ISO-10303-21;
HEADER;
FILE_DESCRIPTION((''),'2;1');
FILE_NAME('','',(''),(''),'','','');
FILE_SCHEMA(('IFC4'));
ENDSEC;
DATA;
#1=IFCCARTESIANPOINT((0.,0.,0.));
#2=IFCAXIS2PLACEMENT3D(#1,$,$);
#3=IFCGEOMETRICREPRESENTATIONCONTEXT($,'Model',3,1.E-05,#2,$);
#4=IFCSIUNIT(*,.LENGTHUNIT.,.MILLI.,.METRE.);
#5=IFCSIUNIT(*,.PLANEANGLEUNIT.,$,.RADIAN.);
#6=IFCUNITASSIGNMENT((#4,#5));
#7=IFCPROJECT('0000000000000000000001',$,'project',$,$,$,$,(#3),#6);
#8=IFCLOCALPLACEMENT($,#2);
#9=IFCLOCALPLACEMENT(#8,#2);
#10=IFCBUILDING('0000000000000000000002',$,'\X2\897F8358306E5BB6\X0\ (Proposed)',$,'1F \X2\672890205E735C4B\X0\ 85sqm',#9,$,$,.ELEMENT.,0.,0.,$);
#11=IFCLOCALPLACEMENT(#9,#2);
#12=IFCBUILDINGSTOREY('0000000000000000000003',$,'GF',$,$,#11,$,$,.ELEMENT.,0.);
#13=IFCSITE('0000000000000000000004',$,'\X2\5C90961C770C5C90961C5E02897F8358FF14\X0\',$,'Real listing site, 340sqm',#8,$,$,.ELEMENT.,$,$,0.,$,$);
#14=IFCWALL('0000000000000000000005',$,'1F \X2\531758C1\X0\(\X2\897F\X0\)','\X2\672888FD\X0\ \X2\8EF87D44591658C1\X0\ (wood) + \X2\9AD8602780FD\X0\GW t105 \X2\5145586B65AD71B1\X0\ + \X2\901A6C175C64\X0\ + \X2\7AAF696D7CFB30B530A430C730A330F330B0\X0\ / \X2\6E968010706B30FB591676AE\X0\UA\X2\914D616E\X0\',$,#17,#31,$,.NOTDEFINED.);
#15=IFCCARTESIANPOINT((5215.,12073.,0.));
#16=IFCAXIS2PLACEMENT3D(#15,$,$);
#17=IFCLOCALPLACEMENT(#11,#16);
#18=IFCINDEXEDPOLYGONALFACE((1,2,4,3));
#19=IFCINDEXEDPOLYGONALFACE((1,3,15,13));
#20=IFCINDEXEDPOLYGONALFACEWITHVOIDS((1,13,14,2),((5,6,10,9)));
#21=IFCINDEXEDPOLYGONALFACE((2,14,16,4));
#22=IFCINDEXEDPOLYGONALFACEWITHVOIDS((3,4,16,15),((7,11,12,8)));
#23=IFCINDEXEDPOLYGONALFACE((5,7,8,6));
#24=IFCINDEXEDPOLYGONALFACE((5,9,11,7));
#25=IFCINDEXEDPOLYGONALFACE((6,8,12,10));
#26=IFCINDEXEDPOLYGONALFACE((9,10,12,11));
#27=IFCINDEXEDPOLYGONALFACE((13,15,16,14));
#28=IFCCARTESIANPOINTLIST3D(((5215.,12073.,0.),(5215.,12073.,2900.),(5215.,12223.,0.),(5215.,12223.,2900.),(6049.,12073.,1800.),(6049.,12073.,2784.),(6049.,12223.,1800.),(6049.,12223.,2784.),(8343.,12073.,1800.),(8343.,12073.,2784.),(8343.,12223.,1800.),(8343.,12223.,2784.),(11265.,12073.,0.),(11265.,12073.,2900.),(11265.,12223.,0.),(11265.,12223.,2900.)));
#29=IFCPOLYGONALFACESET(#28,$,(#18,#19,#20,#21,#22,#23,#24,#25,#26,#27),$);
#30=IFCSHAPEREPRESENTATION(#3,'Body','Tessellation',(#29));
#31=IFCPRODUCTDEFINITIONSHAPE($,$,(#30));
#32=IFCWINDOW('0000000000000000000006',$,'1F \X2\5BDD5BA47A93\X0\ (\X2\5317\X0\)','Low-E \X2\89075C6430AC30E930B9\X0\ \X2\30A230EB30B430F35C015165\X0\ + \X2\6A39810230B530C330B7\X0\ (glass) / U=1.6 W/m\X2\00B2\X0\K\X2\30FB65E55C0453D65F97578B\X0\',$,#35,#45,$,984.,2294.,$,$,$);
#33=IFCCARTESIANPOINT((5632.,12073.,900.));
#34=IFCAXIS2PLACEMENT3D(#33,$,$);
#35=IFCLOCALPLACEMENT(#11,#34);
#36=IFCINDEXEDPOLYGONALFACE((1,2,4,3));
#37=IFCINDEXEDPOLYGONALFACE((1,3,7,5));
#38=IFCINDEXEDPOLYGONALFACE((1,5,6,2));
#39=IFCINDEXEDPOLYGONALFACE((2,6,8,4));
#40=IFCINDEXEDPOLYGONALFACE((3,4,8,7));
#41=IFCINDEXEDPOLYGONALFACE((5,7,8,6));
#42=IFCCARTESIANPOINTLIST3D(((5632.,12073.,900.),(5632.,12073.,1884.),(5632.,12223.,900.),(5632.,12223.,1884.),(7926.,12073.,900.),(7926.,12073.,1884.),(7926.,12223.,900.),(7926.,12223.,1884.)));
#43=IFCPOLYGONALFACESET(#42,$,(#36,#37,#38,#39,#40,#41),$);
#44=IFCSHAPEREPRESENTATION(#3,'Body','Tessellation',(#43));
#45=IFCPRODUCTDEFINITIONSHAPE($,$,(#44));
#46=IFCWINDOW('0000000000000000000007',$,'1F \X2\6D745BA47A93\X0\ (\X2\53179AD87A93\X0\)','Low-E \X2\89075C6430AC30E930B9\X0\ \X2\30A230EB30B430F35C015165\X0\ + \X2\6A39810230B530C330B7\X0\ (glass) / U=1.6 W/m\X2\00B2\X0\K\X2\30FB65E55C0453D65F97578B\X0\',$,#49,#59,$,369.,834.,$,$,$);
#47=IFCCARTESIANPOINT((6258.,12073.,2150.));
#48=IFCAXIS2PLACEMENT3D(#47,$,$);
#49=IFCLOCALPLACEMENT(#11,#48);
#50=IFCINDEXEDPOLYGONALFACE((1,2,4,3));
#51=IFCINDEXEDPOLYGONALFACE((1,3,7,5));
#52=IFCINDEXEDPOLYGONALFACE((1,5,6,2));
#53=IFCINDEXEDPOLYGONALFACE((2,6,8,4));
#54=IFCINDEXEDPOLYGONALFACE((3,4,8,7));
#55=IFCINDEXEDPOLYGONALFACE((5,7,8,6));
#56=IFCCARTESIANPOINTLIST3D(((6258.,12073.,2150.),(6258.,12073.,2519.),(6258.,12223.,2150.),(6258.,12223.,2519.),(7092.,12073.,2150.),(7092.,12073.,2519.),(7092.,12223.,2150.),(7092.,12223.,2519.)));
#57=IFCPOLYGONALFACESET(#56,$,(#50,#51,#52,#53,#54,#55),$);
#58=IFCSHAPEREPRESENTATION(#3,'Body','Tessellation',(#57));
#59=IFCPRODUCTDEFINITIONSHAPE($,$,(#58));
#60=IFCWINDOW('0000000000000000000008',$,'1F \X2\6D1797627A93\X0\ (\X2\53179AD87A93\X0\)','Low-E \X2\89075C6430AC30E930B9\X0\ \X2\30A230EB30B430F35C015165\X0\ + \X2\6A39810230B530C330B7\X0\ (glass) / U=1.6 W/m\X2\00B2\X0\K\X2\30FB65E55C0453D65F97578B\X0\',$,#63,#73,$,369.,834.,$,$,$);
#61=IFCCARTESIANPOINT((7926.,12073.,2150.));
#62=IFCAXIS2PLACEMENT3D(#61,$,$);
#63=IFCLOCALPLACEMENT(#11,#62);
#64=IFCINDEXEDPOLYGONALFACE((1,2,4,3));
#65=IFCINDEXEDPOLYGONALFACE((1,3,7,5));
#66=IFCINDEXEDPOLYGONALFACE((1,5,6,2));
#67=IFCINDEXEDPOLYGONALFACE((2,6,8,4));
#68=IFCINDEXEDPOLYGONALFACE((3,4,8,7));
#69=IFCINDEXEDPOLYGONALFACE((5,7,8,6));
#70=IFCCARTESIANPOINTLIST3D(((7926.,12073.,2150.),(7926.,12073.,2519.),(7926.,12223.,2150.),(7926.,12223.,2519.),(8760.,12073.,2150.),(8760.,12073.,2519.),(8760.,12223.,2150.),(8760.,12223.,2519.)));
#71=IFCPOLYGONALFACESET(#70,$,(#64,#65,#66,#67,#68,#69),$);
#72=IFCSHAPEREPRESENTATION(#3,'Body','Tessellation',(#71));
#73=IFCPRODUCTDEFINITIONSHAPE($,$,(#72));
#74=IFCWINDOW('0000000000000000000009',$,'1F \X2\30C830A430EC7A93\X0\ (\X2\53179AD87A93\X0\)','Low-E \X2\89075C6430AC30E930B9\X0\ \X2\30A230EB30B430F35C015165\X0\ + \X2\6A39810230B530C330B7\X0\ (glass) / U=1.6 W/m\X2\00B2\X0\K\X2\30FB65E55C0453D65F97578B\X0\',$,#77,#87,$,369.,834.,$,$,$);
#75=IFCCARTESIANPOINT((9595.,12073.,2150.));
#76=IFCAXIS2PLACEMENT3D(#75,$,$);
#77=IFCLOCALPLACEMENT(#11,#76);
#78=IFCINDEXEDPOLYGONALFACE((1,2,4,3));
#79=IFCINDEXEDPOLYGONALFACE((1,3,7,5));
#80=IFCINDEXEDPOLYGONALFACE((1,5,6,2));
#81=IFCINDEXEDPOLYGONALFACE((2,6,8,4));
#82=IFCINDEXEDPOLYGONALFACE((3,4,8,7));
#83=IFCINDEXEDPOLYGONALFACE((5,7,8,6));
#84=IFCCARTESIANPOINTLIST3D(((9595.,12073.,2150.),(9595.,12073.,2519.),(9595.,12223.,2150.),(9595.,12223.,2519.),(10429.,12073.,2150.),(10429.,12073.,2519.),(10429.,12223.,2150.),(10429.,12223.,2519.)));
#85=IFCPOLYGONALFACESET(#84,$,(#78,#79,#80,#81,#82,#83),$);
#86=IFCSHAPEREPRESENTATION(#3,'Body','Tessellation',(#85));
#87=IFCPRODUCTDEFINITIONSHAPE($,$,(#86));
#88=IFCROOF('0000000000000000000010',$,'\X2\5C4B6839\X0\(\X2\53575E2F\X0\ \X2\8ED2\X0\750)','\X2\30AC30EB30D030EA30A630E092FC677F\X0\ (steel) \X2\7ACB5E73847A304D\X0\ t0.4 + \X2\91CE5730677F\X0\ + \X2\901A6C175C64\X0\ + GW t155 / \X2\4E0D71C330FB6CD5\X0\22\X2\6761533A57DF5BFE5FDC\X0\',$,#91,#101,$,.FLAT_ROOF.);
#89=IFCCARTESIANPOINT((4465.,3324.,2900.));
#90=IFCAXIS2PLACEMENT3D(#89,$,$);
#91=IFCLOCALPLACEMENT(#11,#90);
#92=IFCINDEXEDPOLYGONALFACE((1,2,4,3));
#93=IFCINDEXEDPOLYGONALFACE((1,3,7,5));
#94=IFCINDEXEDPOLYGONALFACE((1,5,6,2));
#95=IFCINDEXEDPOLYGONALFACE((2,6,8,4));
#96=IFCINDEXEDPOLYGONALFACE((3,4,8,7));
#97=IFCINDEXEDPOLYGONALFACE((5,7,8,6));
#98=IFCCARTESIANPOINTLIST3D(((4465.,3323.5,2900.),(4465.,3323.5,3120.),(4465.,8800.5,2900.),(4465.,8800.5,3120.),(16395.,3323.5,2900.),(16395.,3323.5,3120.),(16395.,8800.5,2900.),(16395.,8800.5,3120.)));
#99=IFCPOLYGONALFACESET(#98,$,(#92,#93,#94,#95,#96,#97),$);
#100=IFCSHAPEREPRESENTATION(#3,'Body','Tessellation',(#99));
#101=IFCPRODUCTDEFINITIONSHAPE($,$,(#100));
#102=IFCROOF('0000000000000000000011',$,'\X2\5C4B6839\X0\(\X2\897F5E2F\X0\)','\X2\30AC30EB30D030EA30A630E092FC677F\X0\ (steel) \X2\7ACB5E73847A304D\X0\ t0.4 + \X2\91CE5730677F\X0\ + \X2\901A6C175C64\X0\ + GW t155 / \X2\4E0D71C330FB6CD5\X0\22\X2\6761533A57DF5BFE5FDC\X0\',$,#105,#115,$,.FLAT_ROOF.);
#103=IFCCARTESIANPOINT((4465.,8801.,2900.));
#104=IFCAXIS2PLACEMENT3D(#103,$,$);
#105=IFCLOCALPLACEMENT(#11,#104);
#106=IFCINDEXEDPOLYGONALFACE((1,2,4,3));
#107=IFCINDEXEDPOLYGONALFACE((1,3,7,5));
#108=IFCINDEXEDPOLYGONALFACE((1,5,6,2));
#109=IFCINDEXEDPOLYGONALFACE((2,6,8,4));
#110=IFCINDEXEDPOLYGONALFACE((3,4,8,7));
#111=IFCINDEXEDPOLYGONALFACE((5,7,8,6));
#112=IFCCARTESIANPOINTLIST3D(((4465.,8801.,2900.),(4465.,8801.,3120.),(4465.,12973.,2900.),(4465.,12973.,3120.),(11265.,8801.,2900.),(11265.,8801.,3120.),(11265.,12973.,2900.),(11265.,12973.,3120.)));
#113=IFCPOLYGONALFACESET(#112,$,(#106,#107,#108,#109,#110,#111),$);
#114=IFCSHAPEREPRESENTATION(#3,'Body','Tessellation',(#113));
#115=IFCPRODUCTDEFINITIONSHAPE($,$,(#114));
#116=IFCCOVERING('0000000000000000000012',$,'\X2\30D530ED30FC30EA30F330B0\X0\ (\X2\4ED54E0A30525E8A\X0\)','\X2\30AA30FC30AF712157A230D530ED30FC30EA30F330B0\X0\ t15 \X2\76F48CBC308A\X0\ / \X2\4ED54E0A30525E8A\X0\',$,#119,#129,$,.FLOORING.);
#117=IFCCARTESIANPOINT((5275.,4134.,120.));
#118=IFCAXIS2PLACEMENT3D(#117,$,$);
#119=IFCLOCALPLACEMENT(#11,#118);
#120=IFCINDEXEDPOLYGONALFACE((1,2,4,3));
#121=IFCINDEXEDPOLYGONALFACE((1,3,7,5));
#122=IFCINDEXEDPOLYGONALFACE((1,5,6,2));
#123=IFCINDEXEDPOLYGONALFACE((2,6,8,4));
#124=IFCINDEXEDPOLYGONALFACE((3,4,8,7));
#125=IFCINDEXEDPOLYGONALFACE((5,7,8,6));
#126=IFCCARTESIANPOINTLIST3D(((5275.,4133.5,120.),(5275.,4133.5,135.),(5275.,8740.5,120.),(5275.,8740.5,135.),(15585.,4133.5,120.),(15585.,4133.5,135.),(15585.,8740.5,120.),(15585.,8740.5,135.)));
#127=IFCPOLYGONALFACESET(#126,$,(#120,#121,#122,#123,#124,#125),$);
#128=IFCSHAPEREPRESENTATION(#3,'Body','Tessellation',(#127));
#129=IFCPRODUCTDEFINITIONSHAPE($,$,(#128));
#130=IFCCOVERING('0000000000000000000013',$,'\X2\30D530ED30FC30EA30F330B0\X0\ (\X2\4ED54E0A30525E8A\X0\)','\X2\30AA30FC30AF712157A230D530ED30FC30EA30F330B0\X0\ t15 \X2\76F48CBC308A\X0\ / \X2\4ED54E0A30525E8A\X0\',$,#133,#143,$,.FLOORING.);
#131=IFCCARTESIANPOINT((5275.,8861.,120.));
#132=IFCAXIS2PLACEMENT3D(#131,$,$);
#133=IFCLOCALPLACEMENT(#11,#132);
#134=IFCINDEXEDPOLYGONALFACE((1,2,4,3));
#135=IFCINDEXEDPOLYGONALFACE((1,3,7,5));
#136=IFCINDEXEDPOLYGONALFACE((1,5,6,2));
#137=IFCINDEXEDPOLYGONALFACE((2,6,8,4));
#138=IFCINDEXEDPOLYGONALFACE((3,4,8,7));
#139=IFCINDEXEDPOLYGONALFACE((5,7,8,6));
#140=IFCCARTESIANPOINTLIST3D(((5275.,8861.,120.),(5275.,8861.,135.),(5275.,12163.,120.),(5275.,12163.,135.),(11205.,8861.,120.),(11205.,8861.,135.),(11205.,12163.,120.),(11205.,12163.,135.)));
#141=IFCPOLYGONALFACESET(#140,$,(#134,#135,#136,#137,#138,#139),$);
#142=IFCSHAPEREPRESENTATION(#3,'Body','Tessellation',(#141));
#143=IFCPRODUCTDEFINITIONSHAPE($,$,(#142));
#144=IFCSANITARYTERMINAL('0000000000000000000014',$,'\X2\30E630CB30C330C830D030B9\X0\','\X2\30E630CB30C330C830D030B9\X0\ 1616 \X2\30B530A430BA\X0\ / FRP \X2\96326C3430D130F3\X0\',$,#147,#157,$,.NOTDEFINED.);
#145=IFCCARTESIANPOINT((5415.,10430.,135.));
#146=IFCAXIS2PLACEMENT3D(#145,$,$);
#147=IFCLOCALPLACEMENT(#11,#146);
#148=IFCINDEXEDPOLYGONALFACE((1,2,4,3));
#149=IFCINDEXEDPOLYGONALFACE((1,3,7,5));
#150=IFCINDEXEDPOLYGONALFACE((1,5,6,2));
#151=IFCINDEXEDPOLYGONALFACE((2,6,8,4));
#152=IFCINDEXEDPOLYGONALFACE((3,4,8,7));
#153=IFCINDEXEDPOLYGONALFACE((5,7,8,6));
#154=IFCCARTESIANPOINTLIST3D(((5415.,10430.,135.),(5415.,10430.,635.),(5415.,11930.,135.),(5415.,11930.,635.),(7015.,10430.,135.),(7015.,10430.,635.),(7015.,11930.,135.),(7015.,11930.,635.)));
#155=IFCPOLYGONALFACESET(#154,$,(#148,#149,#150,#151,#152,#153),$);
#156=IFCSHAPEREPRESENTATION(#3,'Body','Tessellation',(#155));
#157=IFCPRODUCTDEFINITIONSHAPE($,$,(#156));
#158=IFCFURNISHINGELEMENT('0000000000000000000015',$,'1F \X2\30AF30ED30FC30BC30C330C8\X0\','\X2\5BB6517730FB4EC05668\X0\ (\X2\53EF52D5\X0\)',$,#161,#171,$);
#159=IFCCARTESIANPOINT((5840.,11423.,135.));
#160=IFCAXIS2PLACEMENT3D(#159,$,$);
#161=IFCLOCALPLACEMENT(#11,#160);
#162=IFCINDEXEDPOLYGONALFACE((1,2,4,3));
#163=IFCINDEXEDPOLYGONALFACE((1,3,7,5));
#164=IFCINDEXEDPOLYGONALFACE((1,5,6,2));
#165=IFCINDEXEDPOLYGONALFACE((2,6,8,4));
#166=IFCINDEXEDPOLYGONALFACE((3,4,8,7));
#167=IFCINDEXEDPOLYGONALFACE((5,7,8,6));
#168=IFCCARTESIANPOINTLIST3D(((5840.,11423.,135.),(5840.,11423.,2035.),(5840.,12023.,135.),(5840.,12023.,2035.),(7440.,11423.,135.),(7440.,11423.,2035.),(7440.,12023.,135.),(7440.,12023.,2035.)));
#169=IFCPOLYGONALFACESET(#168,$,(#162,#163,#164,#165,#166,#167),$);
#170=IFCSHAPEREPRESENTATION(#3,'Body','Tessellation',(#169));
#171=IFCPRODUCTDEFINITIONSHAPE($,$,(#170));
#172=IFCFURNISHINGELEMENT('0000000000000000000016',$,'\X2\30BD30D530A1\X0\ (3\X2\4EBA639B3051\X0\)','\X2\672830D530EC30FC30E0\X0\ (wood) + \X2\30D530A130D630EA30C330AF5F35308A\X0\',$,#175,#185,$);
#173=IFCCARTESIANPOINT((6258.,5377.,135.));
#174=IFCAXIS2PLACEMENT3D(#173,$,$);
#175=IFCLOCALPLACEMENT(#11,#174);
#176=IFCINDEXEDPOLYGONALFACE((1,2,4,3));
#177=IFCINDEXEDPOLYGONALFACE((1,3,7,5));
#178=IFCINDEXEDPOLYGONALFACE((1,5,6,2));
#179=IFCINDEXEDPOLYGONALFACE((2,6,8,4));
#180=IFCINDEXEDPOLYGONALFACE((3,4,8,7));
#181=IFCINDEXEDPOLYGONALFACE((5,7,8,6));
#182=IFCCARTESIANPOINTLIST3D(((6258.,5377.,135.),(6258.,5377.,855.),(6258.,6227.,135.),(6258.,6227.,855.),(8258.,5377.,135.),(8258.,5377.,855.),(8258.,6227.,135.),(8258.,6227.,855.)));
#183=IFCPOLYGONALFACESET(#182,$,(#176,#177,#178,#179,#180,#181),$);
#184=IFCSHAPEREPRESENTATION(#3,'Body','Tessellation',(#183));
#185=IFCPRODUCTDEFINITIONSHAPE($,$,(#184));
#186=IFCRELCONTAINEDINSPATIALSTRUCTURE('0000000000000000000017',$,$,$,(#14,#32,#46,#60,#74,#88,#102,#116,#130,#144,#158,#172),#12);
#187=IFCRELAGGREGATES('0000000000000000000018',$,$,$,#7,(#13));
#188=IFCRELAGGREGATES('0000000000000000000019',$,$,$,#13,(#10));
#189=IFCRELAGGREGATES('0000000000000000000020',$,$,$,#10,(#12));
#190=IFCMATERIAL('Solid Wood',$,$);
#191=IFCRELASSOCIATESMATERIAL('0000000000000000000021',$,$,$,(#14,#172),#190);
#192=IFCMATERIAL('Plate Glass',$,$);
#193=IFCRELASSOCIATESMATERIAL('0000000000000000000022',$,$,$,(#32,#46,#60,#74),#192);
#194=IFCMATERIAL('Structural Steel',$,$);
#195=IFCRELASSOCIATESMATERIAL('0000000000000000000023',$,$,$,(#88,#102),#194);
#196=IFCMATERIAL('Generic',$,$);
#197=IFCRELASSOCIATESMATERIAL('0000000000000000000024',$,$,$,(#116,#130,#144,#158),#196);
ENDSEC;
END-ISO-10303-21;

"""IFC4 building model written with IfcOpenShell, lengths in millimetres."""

from ifc_helpers import new_model, si_unit, frame, frame_2d, origin, place, context, project, spatial, rectangle, extrude, material, element, fill, save


model = new_model("IFC4")

# Units and contexts
model_context = context("Model", 3, precision=1e-05, world=origin())
ifc_project = project(units=[si_unit("LENGTHUNIT", "METRE", prefix="MILLI"), si_unit("PLANEANGLEUNIT", "RADIAN")], contexts=[model_context])

# Site, building, storey
site_placement = place(None, origin())
site = spatial("IfcSite", under=ifc_project, at=site_placement, Name="岐阜県岐阜市西荘４", ObjectType="Real listing site, 340sqm", CompositionType="ELEMENT", RefElevation=0.0)
building_placement = place(site_placement, origin())
building = spatial("IfcBuilding", under=site, at=building_placement, Name="西荘の家 (Proposed)", ObjectType="1F 木造平屋 85sqm", CompositionType="ELEMENT", ElevationOfRefHeight=0.0, ElevationOfTerrain=0.0)
storey_placement = place(building_placement, origin())
storey = spatial("IfcBuildingStorey", under=building, at=storey_placement, Name="GF", CompositionType="ELEMENT", Elevation=0.0)

# Shared definitions
ifc_material_1 = material(Name="Solid Wood")

# Shared definitions
ifc_material_2 = material(Name="Plate Glass")

# Wall, openings, windows
wall_1_placement = place(storey_placement, frame((5215.0, 12073.0, 0.0)))
wall_1 = element("IfcWall", 1, at=wall_1_placement, inside=storey, material=ifc_material_1, Name="1F 北壁(西)", Description="木製 軸組外壁 (wood) + 高性能GW t105 充填断熱 + 通気層 + 窯業系サイディング / 準耐火・外皮UA配慮", PredefinedType="NOTDEFINED", context=model_context, shape_type="SweptSolid", body=[
    extrude(rectangle(XDim=6050.0, YDim=150.0, at=frame_2d((3025.0, 75.0))), frame((5215.0, 12073.0, 0.0)), (0.0, 0.0, 1.0), 2900.0),
])
opening_1_placement = place(storey_placement, frame((5632.0, 12073.0, 900.0)))
opening_1 = element("IfcOpeningElement", 2, at=opening_1_placement, cuts=wall_1, PredefinedType="NOTDEFINED", context=model_context, shape_type="SweptSolid", body=[
    extrude(rectangle(XDim=2294.0, YDim=150.0, at=frame_2d((1147.0, 75.0))), frame((5632.0, 12073.0, 900.0)), (0.0, 0.0, 1.0), 984.0),
])
opening_2_placement = place(storey_placement, frame((6258.0, 12073.0, 2150.0)))
opening_2 = element("IfcOpeningElement", 3, at=opening_2_placement, cuts=wall_1, PredefinedType="NOTDEFINED", context=model_context, shape_type="SweptSolid", body=[
    extrude(rectangle(XDim=834.0, YDim=150.0, at=frame_2d((417.0, 75.0))), frame((6258.0, 12073.0, 2150.0)), (0.0, 0.0, 1.0), 369.0),
])
opening_3_placement = place(storey_placement, frame((7926.0, 12073.0, 2150.0)))
opening_3 = element("IfcOpeningElement", 4, at=opening_3_placement, cuts=wall_1, PredefinedType="NOTDEFINED", context=model_context, shape_type="SweptSolid", body=[
    extrude(rectangle(XDim=834.0, YDim=150.0, at=frame_2d((417.0, 75.0))), frame((7926.0, 12073.0, 2150.0)), (0.0, 0.0, 1.0), 369.0),
])
opening_4_placement = place(storey_placement, frame((9595.0, 12073.0, 2150.0)))
opening_4 = element("IfcOpeningElement", 5, at=opening_4_placement, cuts=wall_1, PredefinedType="NOTDEFINED", context=model_context, shape_type="SweptSolid", body=[
    extrude(rectangle(XDim=834.0, YDim=150.0, at=frame_2d((417.0, 75.0))), frame((9595.0, 12073.0, 2150.0)), (0.0, 0.0, 1.0), 369.0),
])
window_1_placement = place(storey_placement, frame((5632.0, 12073.0, 900.0)))
window_1 = element("IfcWindow", 6, at=window_1_placement, inside=storey, material=ifc_material_2, Name="1F 寝室窓 (北)", Description="Low-E 複層ガラス アルゴン封入 + 樹脂サッシ (glass) / U=1.6 W/m²K・日射取得型", OverallHeight=984.0, OverallWidth=2294.0, context=model_context, shape_type="SweptSolid", body=[
    extrude(rectangle(XDim=2294.0, YDim=150.0, at=frame_2d((1147.0, 75.0))), frame((5632.0, 12073.0, 900.0)), (0.0, 0.0, 1.0), 984.0),
])
fill(opening_1, window_1)
window_2_placement = place(storey_placement, frame((6258.0, 12073.0, 2150.0)))
window_2 = element("IfcWindow", 7, at=window_2_placement, inside=storey, material=ifc_material_2, Name="1F 浴室窓 (北高窓)", Description="Low-E 複層ガラス アルゴン封入 + 樹脂サッシ (glass) / U=1.6 W/m²K・日射取得型", OverallHeight=369.0, OverallWidth=834.0, context=model_context, shape_type="SweptSolid", body=[
    extrude(rectangle(XDim=834.0, YDim=150.0, at=frame_2d((417.0, 75.0))), frame((6258.0, 12073.0, 2150.0)), (0.0, 0.0, 1.0), 369.0),
])
fill(opening_2, window_2)
window_3_placement = place(storey_placement, frame((7926.0, 12073.0, 2150.0)))
window_3 = element("IfcWindow", 8, at=window_3_placement, inside=storey, material=ifc_material_2, Name="1F 洗面窓 (北高窓)", Description="Low-E 複層ガラス アルゴン封入 + 樹脂サッシ (glass) / U=1.6 W/m²K・日射取得型", OverallHeight=369.0, OverallWidth=834.0, context=model_context, shape_type="SweptSolid", body=[
    extrude(rectangle(XDim=834.0, YDim=150.0, at=frame_2d((417.0, 75.0))), frame((7926.0, 12073.0, 2150.0)), (0.0, 0.0, 1.0), 369.0),
])
fill(opening_3, window_3)
window_4_placement = place(storey_placement, frame((9595.0, 12073.0, 2150.0)))
window_4 = element("IfcWindow", 9, at=window_4_placement, inside=storey, material=ifc_material_2, Name="1F トイレ窓 (北高窓)", Description="Low-E 複層ガラス アルゴン封入 + 樹脂サッシ (glass) / U=1.6 W/m²K・日射取得型", OverallHeight=369.0, OverallWidth=834.0, context=model_context, shape_type="SweptSolid", body=[
    extrude(rectangle(XDim=834.0, YDim=150.0, at=frame_2d((417.0, 75.0))), frame((9595.0, 12073.0, 2150.0)), (0.0, 0.0, 1.0), 369.0),
])
fill(opening_4, window_4)

# Roofs
ifc_material_3 = material(Name="Structural Steel")
roof_1_placement = place(storey_placement, frame((4465.0, 3324.0, 2900.0)))
element("IfcRoof", 10, at=roof_1_placement, inside=storey, material=ifc_material_3, Name="屋根(南帯 軒750)", Description="ガルバリウム鋼板 (steel) 立平葺き t0.4 + 野地板 + 通気層 + GW t155 / 不燃・法22条区域対応", PredefinedType="FLAT_ROOF", context=model_context, shape_type="SweptSolid", body=[
    extrude(rectangle(XDim=11930.0, YDim=5477.0, at=frame_2d((5965.0, 2738.0))), frame((4465.0, 3324.0, 2900.0)), (0.0, 0.0, 1.0), 220.0),
])
roof_2_placement = place(storey_placement, frame((4465.0, 8801.0, 2900.0)))
element("IfcRoof", 11, at=roof_2_placement, inside=storey, material=ifc_material_3, Name="屋根(西帯)", Description="ガルバリウム鋼板 (steel) 立平葺き t0.4 + 野地板 + 通気層 + GW t155 / 不燃・法22条区域対応", PredefinedType="FLAT_ROOF", context=model_context, shape_type="SweptSolid", body=[
    extrude(rectangle(XDim=6800.0, YDim=4172.0, at=frame_2d((3400.0, 2086.0))), frame((4465.0, 8801.0, 2900.0)), (0.0, 0.0, 1.0), 220.0),
])

# Coverings
ifc_material_4 = material(Name="Generic")
covering_1_placement = place(storey_placement, frame((5275.0, 4134.0, 120.0)))
element("IfcCovering", 12, at=covering_1_placement, inside=storey, material=ifc_material_4, Name="フローリング (仕上げ床)", Description="オーク無垢フローリング t15 直貼り / 仕上げ床", PredefinedType="FLOORING", context=model_context, shape_type="SweptSolid", body=[
    extrude(rectangle(XDim=10310.0, YDim=4607.0, at=frame_2d((5155.0, 2303.0))), frame((5275.0, 4134.0, 120.0)), (0.0, 0.0, 1.0), 15.0),
])
covering_2_placement = place(storey_placement, frame((5275.0, 8861.0, 120.0)))
element("IfcCovering", 13, at=covering_2_placement, inside=storey, material=ifc_material_4, Name="フローリング (仕上げ床)", Description="オーク無垢フローリング t15 直貼り / 仕上げ床", PredefinedType="FLOORING", context=model_context, shape_type="SweptSolid", body=[
    extrude(rectangle(XDim=5930.0, YDim=3302.0, at=frame_2d((2965.0, 1651.0))), frame((5275.0, 8861.0, 120.0)), (0.0, 0.0, 1.0), 15.0),
])

# Sanitary terminal
sanitary_terminal_placement = place(storey_placement, frame((5415.0, 10430.0, 135.0)))
element("IfcSanitaryTerminal", 14, at=sanitary_terminal_placement, inside=storey, material=ifc_material_4, Name="ユニットバス", Description="ユニットバス 1616 サイズ / FRP 防水パン", PredefinedType="NOTDEFINED", context=model_context, shape_type="SweptSolid", body=[
    extrude(rectangle(XDim=1600.0, YDim=1500.0, at=frame_2d((800.0, 750.0))), frame((5415.0, 10430.0, 135.0)), (0.0, 0.0, 1.0), 500.0),
])

# Furnishing elements
furnishing_1_placement = place(storey_placement, frame((5840.0, 11423.0, 135.0)))
element("IfcFurnishingElement", 15, at=furnishing_1_placement, inside=storey, material=ifc_material_4, Name="1F クローゼット", Description="家具・什器 (可動)", context=model_context, shape_type="SweptSolid", body=[
    extrude(rectangle(XDim=1600.0, YDim=600.0, at=frame_2d((800.0, 300.0))), frame((5840.0, 11423.0, 135.0)), (0.0, 0.0, 1.0), 1900.0),
])
furnishing_2_placement = place(storey_placement, frame((6258.0, 5377.0, 135.0)))
element("IfcFurnishingElement", 16, at=furnishing_2_placement, inside=storey, material=ifc_material_1, Name="ソファ (3人掛け)", Description="木フレーム (wood) + ファブリック張り", context=model_context, shape_type="SweptSolid", body=[
    extrude(rectangle(XDim=2000.0, YDim=850.0, at=frame_2d((1000.0, 425.0))), frame((6258.0, 5377.0, 135.0)), (0.0, 0.0, 1.0), 720.0),
])

save(model, "model.ifc")
